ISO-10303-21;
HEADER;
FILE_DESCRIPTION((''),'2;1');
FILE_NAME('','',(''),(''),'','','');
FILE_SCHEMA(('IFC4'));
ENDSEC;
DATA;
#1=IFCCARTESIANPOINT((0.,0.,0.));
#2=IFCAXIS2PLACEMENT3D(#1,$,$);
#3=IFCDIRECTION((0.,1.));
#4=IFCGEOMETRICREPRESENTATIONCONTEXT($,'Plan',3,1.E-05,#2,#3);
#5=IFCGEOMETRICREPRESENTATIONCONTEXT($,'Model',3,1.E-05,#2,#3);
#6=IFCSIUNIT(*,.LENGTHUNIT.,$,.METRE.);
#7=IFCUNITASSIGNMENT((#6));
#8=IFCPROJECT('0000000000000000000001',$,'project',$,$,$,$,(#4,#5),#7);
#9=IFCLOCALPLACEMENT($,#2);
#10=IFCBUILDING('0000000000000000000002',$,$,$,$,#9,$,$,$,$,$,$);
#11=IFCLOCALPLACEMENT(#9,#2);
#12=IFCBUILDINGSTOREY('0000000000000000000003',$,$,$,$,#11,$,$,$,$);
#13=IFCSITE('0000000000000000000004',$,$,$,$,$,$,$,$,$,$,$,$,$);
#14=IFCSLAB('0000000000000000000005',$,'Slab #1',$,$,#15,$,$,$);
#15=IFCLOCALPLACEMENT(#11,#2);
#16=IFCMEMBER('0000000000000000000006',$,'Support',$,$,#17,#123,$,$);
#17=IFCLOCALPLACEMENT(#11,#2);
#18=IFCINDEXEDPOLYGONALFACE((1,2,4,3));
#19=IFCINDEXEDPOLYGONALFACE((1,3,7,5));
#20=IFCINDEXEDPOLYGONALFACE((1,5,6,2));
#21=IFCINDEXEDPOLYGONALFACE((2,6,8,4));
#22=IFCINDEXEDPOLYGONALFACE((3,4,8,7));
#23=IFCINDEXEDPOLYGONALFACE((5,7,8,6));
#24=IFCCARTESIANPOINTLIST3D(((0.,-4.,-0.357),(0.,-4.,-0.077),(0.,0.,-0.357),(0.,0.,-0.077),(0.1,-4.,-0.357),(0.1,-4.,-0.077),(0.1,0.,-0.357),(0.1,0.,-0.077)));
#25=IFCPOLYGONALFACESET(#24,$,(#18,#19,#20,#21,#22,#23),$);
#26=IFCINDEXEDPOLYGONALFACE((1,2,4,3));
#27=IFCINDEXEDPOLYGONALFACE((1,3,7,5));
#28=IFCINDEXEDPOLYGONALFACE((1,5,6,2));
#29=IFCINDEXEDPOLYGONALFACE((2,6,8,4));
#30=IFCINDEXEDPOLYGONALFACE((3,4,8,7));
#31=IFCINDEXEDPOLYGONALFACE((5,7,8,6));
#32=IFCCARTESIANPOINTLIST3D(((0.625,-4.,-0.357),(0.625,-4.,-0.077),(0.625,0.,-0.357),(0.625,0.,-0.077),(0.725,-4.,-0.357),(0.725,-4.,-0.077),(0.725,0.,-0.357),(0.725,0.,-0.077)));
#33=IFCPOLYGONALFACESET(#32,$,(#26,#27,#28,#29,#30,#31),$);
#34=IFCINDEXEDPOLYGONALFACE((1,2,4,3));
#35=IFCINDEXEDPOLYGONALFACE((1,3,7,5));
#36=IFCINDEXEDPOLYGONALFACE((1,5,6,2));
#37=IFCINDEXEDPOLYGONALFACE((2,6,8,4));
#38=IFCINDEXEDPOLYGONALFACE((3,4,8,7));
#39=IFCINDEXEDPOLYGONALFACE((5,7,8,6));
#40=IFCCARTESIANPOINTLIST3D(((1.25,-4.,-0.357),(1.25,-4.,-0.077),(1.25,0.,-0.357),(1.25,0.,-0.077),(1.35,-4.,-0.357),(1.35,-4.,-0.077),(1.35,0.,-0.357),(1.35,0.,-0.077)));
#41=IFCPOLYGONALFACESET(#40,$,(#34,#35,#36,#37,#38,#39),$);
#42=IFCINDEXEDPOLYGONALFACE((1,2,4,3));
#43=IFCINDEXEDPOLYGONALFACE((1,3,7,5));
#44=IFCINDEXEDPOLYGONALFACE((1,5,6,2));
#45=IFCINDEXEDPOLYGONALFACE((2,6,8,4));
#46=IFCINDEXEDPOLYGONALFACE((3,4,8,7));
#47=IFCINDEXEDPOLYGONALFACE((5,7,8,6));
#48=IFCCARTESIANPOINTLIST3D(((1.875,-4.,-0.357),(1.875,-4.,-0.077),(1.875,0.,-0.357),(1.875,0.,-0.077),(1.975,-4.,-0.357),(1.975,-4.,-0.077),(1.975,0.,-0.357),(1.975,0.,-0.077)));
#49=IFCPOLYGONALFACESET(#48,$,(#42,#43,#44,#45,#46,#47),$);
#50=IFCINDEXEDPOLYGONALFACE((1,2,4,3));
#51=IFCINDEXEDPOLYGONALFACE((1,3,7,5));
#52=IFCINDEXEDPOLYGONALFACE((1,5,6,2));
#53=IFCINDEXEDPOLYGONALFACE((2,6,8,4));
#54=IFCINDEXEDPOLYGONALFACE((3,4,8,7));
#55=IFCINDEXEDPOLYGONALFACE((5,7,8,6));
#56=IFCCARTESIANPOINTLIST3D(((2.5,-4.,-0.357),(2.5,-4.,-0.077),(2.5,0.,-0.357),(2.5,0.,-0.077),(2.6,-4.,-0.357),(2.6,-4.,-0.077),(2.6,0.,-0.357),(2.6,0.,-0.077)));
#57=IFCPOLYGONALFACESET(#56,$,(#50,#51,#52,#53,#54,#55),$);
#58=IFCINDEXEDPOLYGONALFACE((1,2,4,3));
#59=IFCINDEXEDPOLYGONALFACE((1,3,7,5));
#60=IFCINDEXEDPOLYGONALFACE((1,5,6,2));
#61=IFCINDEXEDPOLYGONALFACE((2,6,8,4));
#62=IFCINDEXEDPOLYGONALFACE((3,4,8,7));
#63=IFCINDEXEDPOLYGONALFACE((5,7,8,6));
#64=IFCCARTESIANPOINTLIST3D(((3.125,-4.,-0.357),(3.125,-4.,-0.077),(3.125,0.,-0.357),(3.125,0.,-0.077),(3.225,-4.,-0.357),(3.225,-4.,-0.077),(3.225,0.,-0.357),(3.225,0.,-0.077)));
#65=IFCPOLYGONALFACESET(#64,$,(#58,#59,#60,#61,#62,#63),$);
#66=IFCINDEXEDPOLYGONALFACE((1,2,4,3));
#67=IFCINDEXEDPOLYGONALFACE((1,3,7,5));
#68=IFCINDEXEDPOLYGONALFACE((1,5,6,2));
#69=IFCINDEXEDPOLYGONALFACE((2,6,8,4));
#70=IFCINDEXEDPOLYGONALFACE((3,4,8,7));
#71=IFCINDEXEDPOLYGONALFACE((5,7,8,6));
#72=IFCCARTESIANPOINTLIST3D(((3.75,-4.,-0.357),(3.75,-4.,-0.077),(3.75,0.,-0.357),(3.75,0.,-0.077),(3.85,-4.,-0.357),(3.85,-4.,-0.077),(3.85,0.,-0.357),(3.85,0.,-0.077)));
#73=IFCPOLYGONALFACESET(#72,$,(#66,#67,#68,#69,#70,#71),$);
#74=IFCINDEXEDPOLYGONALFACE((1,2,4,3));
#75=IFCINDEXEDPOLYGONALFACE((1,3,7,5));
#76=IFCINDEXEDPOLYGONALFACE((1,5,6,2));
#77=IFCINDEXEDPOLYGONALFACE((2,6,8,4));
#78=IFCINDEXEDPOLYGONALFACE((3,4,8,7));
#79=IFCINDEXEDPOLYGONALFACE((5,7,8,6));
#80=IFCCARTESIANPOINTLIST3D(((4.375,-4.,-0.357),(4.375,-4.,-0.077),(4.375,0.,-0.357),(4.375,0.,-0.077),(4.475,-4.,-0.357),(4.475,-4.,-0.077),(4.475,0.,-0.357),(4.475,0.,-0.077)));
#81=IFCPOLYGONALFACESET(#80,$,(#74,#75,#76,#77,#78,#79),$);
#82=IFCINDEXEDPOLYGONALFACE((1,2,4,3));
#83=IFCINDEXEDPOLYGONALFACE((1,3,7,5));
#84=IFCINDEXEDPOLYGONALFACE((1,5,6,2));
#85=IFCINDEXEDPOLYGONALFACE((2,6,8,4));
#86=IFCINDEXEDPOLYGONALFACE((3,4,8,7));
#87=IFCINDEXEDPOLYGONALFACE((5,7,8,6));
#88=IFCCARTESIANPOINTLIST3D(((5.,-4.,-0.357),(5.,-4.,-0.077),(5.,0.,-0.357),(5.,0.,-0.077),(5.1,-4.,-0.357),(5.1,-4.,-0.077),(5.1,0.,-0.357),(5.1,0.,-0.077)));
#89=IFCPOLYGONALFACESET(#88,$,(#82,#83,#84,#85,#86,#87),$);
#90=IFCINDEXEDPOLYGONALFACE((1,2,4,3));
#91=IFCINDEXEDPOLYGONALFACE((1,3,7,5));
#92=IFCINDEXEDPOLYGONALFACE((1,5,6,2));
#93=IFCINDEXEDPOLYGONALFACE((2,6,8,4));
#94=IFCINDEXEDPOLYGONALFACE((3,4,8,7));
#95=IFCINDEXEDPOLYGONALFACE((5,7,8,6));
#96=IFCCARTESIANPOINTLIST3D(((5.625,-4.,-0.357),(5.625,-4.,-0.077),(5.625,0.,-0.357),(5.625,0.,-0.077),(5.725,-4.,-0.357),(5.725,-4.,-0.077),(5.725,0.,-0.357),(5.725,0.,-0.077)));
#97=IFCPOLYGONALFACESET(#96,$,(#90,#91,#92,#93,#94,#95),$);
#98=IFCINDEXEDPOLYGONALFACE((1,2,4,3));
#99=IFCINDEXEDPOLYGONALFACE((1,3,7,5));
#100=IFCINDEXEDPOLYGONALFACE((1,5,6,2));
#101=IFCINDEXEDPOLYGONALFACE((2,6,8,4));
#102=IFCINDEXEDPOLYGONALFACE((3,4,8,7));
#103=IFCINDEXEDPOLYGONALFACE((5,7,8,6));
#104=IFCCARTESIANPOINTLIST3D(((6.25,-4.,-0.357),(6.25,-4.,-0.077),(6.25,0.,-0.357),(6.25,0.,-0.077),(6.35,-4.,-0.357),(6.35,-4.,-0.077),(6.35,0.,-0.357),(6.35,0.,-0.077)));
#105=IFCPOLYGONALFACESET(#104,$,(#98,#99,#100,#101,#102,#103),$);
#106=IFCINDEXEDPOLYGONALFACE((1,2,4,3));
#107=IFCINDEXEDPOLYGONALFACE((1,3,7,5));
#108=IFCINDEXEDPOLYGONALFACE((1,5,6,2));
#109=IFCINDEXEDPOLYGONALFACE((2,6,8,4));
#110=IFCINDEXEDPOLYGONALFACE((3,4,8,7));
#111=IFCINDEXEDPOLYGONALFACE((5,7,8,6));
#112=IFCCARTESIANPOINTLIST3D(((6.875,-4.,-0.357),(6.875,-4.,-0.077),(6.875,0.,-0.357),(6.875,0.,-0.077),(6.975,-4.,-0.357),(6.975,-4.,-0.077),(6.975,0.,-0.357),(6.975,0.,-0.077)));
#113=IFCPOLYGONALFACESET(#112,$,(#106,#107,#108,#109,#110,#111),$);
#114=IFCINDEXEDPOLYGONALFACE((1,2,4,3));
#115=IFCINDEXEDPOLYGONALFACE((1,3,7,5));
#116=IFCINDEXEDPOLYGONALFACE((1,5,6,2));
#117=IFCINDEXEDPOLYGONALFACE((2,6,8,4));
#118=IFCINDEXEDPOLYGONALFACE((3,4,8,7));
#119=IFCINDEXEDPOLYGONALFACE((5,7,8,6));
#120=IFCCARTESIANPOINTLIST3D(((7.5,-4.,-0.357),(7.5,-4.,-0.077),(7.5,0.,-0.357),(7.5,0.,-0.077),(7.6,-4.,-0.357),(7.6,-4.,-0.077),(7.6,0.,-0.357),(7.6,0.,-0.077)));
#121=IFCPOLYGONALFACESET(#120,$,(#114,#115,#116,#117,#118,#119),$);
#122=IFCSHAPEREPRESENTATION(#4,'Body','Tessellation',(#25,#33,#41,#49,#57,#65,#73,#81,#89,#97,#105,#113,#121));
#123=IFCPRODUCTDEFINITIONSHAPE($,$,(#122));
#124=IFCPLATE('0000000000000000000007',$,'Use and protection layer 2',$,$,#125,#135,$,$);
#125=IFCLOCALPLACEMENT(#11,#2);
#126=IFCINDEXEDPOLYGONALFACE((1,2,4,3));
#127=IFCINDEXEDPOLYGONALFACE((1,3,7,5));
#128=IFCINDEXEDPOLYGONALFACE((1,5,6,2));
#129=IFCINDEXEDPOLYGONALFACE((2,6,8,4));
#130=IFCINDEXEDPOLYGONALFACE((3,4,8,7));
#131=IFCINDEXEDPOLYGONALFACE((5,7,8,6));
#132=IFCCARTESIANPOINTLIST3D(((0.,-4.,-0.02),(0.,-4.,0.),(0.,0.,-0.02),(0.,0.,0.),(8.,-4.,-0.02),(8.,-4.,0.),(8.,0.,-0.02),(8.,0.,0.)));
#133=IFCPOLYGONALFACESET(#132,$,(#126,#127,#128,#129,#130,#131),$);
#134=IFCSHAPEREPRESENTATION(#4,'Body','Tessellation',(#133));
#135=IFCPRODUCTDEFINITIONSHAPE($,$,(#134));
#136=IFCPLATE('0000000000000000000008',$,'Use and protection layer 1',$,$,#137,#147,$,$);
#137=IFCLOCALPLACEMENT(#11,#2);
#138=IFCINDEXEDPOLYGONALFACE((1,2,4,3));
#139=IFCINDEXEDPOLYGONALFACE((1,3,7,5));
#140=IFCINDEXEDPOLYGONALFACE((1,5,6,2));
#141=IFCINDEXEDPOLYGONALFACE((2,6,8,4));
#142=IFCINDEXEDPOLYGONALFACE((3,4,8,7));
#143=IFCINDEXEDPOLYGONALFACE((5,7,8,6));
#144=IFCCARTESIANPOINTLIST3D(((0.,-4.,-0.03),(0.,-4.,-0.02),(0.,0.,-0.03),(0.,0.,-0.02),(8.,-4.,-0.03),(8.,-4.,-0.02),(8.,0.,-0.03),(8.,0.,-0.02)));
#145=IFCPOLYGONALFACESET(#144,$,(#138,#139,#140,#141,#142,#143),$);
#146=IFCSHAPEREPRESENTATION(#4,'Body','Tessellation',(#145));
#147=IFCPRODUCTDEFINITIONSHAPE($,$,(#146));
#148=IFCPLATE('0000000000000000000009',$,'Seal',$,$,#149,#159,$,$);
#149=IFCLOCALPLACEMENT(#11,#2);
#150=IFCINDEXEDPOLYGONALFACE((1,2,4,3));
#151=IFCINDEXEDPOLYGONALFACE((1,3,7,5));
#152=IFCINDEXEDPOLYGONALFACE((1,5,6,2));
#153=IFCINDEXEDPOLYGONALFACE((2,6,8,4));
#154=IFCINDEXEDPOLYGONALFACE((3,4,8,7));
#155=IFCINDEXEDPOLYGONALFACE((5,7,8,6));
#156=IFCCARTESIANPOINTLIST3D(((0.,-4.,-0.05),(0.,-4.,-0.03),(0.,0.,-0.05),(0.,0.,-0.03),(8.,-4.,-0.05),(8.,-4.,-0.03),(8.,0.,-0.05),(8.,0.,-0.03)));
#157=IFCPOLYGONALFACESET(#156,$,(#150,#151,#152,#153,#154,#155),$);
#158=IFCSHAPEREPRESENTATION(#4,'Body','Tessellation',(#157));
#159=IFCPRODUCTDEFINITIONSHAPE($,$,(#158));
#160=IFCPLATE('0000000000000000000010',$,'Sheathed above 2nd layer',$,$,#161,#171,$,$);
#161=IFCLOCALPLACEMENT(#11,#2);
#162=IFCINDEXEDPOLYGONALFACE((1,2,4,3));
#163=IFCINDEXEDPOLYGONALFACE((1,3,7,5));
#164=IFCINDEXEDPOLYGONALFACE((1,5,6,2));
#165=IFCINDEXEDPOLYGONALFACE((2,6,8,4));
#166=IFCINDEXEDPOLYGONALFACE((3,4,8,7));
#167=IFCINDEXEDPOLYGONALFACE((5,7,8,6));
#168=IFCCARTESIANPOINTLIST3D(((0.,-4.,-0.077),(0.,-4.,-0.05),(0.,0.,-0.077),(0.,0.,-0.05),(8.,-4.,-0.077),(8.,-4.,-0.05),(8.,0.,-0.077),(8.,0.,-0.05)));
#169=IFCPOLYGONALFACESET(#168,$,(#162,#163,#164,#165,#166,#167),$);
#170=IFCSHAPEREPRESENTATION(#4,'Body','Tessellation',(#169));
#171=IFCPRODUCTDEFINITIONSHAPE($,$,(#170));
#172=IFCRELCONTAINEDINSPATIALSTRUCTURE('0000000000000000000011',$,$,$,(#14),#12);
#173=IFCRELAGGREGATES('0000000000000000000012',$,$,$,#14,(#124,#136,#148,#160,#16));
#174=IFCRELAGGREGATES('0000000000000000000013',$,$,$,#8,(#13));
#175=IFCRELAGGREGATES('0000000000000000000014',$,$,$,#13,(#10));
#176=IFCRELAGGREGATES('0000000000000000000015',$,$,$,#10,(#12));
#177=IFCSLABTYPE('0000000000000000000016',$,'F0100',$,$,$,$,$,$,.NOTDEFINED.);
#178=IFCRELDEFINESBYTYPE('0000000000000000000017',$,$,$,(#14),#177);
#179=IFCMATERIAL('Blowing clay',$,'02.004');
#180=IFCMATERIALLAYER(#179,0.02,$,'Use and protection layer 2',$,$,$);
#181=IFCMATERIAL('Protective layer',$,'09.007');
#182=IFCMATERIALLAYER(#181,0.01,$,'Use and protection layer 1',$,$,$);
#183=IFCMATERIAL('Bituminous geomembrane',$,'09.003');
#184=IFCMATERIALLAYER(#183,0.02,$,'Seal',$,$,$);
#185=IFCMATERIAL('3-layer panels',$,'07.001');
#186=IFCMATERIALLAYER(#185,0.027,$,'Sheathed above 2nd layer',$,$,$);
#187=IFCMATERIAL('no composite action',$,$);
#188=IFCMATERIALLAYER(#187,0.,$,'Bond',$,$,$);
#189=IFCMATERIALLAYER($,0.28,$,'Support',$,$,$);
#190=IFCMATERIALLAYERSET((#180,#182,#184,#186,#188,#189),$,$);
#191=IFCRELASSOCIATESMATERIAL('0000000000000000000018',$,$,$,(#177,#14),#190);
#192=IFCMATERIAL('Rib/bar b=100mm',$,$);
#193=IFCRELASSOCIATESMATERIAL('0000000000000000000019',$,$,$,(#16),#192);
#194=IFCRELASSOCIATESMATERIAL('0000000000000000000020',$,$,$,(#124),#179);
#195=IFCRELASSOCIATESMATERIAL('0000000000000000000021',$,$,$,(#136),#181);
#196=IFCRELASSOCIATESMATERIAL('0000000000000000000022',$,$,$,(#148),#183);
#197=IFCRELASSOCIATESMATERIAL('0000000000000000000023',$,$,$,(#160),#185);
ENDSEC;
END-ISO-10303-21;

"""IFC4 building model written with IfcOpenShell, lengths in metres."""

from ifc_helpers import new_model, si_unit, direction, frame, frame_2d, origin, origin_with_axes, place, context, project, spatial, rectangle, extrude, material, layer, layer_set, type_object, element, aggregate, save


model = new_model("IFC4")

# Units and contexts
plan_context = context("Plan", 3, precision=1e-05, world=origin(), true_north=direction((0.0, 1.0)))
model_context = context("Model", 3, precision=1e-05, world=origin(), true_north=direction((0.0, 1.0)))
ifc_project = project(units=[si_unit("LENGTHUNIT", "METRE")], contexts=[plan_context, model_context])

# Site, building, storey
site = spatial("IfcSite", under=ifc_project)
building_placement = place(None, origin())
building = spatial("IfcBuilding", under=site, at=building_placement)
storey_placement = place(building_placement, origin())
storey = spatial("IfcBuildingStorey", under=building, at=storey_placement)

# Slab, member, plates
ifc_material_1 = material(Name="Blowing clay", Category="02.004")
ifc_layer_1 = layer(ifc_material_1, 0.02, Name="Use and protection layer 2")
ifc_material_2 = material(Name="Protective layer", Category="09.007")
ifc_layer_2 = layer(ifc_material_2, 0.01, Name="Use and protection layer 1")
ifc_material_3 = material(Name="Bituminous geomembrane", Category="09.003")
ifc_layer_3 = layer(ifc_material_3, 0.02, Name="Seal")
ifc_material_4 = material(Name="3-layer panels", Category="07.001")
ifc_layer_4 = layer(ifc_material_4, 0.027, Name="Sheathed above 2nd layer")
ifc_material_5 = material(Name="no composite action")
ifc_layer_5 = layer(ifc_material_5, 0.0, Name="Bond")
ifc_layer_6 = layer(None, 0.28, Name="Support")
ifc_layer_set = layer_set([ifc_layer_1, ifc_layer_2, ifc_layer_3, ifc_layer_4, ifc_layer_5, ifc_layer_6])
slab_type = type_object("IfcSlabType", Name="F0100", PredefinedType="NOTDEFINED", material=ifc_layer_set)
slab_placement = place(None, frame((0.0, 0.0, 0.0), z_axis=(0.0, 0.0, -1.0), x_axis=(1.0, 0.0, 0.0)))
slab = element("IfcSlab", 1, at=slab_placement, inside=storey, type_object=slab_type, material=ifc_layer_set, Name="Slab #1")
ifc_material_6 = material(Name="Rib/bar b=100mm")
member_placement = place(slab_placement, origin())
member = element("IfcMember", 2, at=member_placement, material=ifc_material_6, Name="Support", context=plan_context, shape_type="SweptSolid", body=[
    extrude(rectangle(XDim=0.1, YDim=0.28, at=frame_2d((0.05, 0.14), x_axis=(1.0, 0.0))), frame((0.0, 4.0, 0.077), z_axis=(0.0, -1.0, 0.0), x_axis=(1.0, 0.0, 0.0)), (0.0, 0.0, 1.0), 4.0),
    extrude(rectangle(XDim=0.1, YDim=0.28, at=frame_2d((0.05, 0.14), x_axis=(1.0, 0.0))), frame((0.625, 4.0, 0.077), z_axis=(0.0, -1.0, 0.0), x_axis=(1.0, 0.0, 0.0)), (0.0, 0.0, 1.0), 4.0),
    extrude(rectangle(XDim=0.1, YDim=0.28, at=frame_2d((0.05, 0.14), x_axis=(1.0, 0.0))), frame((1.25, 4.0, 0.077), z_axis=(0.0, -1.0, 0.0), x_axis=(1.0, 0.0, 0.0)), (0.0, 0.0, 1.0), 4.0),
    extrude(rectangle(XDim=0.1, YDim=0.28, at=frame_2d((0.05, 0.14), x_axis=(1.0, 0.0))), frame((1.875, 4.0, 0.077), z_axis=(0.0, -1.0, 0.0), x_axis=(1.0, 0.0, 0.0)), (0.0, 0.0, 1.0), 4.0),
    extrude(rectangle(XDim=0.1, YDim=0.28, at=frame_2d((0.05, 0.14), x_axis=(1.0, 0.0))), frame((2.5, 4.0, 0.077), z_axis=(0.0, -1.0, 0.0), x_axis=(1.0, 0.0, 0.0)), (0.0, 0.0, 1.0), 4.0),
    extrude(rectangle(XDim=0.1, YDim=0.28, at=frame_2d((0.05, 0.14), x_axis=(1.0, 0.0))), frame((3.125, 4.0, 0.077), z_axis=(0.0, -1.0, 0.0), x_axis=(1.0, 0.0, 0.0)), (0.0, 0.0, 1.0), 4.0),
    extrude(rectangle(XDim=0.1, YDim=0.28, at=frame_2d((0.05, 0.14), x_axis=(1.0, 0.0))), frame((3.75, 4.0, 0.077), z_axis=(0.0, -1.0, 0.0), x_axis=(1.0, 0.0, 0.0)), (0.0, 0.0, 1.0), 4.0),
    extrude(rectangle(XDim=0.1, YDim=0.28, at=frame_2d((0.05, 0.14), x_axis=(1.0, 0.0))), frame((4.375, 4.0, 0.077), z_axis=(0.0, -1.0, 0.0), x_axis=(1.0, 0.0, 0.0)), (0.0, 0.0, 1.0), 4.0),
    extrude(rectangle(XDim=0.1, YDim=0.28, at=frame_2d((0.05, 0.14), x_axis=(1.0, 0.0))), frame((5.0, 4.0, 0.077), z_axis=(0.0, -1.0, 0.0), x_axis=(1.0, 0.0, 0.0)), (0.0, 0.0, 1.0), 4.0),
    extrude(rectangle(XDim=0.1, YDim=0.28, at=frame_2d((0.05, 0.14), x_axis=(1.0, 0.0))), frame((5.625, 4.0, 0.077), z_axis=(0.0, -1.0, 0.0), x_axis=(1.0, 0.0, 0.0)), (0.0, 0.0, 1.0), 4.0),
    extrude(rectangle(XDim=0.1, YDim=0.28, at=frame_2d((0.05, 0.14), x_axis=(1.0, 0.0))), frame((6.25, 4.0, 0.077), z_axis=(0.0, -1.0, 0.0), x_axis=(1.0, 0.0, 0.0)), (0.0, 0.0, 1.0), 4.0),
    extrude(rectangle(XDim=0.1, YDim=0.28, at=frame_2d((0.05, 0.14), x_axis=(1.0, 0.0))), frame((6.875, 4.0, 0.077), z_axis=(0.0, -1.0, 0.0), x_axis=(1.0, 0.0, 0.0)), (0.0, 0.0, 1.0), 4.0),
    extrude(rectangle(XDim=0.1, YDim=0.28, at=frame_2d((0.05, 0.14), x_axis=(1.0, 0.0))), frame((7.5, 4.0, 0.077), z_axis=(0.0, -1.0, 0.0), x_axis=(1.0, 0.0, 0.0)), (0.0, 0.0, 1.0), 4.0),
])
plate_1_placement = place(slab_placement, origin())
plate_1 = element("IfcPlate", 3, at=plate_1_placement, material=ifc_material_1, Name="Use and protection layer 2", context=plan_context, shape_type="SweptSolid", body=[
    extrude(rectangle(XDim=8.0, YDim=4.0, at=frame_2d((4.0, 2.0), x_axis=(1.0, 0.0))), origin_with_axes(), (0.0, 0.0, 1.0), 0.02),
])
plate_2_placement = place(slab_placement, origin())
plate_2 = element("IfcPlate", 4, at=plate_2_placement, material=ifc_material_2, Name="Use and protection layer 1", context=plan_context, shape_type="SweptSolid", body=[
    extrude(rectangle(XDim=8.0, YDim=4.0, at=frame_2d((4.0, 2.0), x_axis=(1.0, 0.0))), frame((0.0, 0.0, 0.02), z_axis=(0.0, 0.0, 1.0), x_axis=(1.0, 0.0, 0.0)), (0.0, 0.0, 1.0), 0.01),
])
plate_3_placement = place(slab_placement, origin())
plate_3 = element("IfcPlate", 5, at=plate_3_placement, material=ifc_material_3, Name="Seal", context=plan_context, shape_type="SweptSolid", body=[
    extrude(rectangle(XDim=8.0, YDim=4.0, at=frame_2d((4.0, 2.0), x_axis=(1.0, 0.0))), frame((0.0, 0.0, 0.03), z_axis=(0.0, 0.0, 1.0), x_axis=(1.0, 0.0, 0.0)), (0.0, 0.0, 1.0), 0.02),
])
plate_4_placement = place(slab_placement, origin())
plate_4 = element("IfcPlate", 6, at=plate_4_placement, material=ifc_material_4, Name="Sheathed above 2nd layer", context=plan_context, shape_type="SweptSolid", body=[
    extrude(rectangle(XDim=8.0, YDim=4.0, at=frame_2d((4.0, 2.0), x_axis=(1.0, 0.0))), frame((0.0, 0.0, 0.05), z_axis=(0.0, 0.0, 1.0), x_axis=(1.0, 0.0, 0.0)), (0.0, 0.0, 1.0), 0.027),
])
aggregate(slab, [plate_1, plate_2, plate_3, plate_4, member])

save(model, "model.ifc")
